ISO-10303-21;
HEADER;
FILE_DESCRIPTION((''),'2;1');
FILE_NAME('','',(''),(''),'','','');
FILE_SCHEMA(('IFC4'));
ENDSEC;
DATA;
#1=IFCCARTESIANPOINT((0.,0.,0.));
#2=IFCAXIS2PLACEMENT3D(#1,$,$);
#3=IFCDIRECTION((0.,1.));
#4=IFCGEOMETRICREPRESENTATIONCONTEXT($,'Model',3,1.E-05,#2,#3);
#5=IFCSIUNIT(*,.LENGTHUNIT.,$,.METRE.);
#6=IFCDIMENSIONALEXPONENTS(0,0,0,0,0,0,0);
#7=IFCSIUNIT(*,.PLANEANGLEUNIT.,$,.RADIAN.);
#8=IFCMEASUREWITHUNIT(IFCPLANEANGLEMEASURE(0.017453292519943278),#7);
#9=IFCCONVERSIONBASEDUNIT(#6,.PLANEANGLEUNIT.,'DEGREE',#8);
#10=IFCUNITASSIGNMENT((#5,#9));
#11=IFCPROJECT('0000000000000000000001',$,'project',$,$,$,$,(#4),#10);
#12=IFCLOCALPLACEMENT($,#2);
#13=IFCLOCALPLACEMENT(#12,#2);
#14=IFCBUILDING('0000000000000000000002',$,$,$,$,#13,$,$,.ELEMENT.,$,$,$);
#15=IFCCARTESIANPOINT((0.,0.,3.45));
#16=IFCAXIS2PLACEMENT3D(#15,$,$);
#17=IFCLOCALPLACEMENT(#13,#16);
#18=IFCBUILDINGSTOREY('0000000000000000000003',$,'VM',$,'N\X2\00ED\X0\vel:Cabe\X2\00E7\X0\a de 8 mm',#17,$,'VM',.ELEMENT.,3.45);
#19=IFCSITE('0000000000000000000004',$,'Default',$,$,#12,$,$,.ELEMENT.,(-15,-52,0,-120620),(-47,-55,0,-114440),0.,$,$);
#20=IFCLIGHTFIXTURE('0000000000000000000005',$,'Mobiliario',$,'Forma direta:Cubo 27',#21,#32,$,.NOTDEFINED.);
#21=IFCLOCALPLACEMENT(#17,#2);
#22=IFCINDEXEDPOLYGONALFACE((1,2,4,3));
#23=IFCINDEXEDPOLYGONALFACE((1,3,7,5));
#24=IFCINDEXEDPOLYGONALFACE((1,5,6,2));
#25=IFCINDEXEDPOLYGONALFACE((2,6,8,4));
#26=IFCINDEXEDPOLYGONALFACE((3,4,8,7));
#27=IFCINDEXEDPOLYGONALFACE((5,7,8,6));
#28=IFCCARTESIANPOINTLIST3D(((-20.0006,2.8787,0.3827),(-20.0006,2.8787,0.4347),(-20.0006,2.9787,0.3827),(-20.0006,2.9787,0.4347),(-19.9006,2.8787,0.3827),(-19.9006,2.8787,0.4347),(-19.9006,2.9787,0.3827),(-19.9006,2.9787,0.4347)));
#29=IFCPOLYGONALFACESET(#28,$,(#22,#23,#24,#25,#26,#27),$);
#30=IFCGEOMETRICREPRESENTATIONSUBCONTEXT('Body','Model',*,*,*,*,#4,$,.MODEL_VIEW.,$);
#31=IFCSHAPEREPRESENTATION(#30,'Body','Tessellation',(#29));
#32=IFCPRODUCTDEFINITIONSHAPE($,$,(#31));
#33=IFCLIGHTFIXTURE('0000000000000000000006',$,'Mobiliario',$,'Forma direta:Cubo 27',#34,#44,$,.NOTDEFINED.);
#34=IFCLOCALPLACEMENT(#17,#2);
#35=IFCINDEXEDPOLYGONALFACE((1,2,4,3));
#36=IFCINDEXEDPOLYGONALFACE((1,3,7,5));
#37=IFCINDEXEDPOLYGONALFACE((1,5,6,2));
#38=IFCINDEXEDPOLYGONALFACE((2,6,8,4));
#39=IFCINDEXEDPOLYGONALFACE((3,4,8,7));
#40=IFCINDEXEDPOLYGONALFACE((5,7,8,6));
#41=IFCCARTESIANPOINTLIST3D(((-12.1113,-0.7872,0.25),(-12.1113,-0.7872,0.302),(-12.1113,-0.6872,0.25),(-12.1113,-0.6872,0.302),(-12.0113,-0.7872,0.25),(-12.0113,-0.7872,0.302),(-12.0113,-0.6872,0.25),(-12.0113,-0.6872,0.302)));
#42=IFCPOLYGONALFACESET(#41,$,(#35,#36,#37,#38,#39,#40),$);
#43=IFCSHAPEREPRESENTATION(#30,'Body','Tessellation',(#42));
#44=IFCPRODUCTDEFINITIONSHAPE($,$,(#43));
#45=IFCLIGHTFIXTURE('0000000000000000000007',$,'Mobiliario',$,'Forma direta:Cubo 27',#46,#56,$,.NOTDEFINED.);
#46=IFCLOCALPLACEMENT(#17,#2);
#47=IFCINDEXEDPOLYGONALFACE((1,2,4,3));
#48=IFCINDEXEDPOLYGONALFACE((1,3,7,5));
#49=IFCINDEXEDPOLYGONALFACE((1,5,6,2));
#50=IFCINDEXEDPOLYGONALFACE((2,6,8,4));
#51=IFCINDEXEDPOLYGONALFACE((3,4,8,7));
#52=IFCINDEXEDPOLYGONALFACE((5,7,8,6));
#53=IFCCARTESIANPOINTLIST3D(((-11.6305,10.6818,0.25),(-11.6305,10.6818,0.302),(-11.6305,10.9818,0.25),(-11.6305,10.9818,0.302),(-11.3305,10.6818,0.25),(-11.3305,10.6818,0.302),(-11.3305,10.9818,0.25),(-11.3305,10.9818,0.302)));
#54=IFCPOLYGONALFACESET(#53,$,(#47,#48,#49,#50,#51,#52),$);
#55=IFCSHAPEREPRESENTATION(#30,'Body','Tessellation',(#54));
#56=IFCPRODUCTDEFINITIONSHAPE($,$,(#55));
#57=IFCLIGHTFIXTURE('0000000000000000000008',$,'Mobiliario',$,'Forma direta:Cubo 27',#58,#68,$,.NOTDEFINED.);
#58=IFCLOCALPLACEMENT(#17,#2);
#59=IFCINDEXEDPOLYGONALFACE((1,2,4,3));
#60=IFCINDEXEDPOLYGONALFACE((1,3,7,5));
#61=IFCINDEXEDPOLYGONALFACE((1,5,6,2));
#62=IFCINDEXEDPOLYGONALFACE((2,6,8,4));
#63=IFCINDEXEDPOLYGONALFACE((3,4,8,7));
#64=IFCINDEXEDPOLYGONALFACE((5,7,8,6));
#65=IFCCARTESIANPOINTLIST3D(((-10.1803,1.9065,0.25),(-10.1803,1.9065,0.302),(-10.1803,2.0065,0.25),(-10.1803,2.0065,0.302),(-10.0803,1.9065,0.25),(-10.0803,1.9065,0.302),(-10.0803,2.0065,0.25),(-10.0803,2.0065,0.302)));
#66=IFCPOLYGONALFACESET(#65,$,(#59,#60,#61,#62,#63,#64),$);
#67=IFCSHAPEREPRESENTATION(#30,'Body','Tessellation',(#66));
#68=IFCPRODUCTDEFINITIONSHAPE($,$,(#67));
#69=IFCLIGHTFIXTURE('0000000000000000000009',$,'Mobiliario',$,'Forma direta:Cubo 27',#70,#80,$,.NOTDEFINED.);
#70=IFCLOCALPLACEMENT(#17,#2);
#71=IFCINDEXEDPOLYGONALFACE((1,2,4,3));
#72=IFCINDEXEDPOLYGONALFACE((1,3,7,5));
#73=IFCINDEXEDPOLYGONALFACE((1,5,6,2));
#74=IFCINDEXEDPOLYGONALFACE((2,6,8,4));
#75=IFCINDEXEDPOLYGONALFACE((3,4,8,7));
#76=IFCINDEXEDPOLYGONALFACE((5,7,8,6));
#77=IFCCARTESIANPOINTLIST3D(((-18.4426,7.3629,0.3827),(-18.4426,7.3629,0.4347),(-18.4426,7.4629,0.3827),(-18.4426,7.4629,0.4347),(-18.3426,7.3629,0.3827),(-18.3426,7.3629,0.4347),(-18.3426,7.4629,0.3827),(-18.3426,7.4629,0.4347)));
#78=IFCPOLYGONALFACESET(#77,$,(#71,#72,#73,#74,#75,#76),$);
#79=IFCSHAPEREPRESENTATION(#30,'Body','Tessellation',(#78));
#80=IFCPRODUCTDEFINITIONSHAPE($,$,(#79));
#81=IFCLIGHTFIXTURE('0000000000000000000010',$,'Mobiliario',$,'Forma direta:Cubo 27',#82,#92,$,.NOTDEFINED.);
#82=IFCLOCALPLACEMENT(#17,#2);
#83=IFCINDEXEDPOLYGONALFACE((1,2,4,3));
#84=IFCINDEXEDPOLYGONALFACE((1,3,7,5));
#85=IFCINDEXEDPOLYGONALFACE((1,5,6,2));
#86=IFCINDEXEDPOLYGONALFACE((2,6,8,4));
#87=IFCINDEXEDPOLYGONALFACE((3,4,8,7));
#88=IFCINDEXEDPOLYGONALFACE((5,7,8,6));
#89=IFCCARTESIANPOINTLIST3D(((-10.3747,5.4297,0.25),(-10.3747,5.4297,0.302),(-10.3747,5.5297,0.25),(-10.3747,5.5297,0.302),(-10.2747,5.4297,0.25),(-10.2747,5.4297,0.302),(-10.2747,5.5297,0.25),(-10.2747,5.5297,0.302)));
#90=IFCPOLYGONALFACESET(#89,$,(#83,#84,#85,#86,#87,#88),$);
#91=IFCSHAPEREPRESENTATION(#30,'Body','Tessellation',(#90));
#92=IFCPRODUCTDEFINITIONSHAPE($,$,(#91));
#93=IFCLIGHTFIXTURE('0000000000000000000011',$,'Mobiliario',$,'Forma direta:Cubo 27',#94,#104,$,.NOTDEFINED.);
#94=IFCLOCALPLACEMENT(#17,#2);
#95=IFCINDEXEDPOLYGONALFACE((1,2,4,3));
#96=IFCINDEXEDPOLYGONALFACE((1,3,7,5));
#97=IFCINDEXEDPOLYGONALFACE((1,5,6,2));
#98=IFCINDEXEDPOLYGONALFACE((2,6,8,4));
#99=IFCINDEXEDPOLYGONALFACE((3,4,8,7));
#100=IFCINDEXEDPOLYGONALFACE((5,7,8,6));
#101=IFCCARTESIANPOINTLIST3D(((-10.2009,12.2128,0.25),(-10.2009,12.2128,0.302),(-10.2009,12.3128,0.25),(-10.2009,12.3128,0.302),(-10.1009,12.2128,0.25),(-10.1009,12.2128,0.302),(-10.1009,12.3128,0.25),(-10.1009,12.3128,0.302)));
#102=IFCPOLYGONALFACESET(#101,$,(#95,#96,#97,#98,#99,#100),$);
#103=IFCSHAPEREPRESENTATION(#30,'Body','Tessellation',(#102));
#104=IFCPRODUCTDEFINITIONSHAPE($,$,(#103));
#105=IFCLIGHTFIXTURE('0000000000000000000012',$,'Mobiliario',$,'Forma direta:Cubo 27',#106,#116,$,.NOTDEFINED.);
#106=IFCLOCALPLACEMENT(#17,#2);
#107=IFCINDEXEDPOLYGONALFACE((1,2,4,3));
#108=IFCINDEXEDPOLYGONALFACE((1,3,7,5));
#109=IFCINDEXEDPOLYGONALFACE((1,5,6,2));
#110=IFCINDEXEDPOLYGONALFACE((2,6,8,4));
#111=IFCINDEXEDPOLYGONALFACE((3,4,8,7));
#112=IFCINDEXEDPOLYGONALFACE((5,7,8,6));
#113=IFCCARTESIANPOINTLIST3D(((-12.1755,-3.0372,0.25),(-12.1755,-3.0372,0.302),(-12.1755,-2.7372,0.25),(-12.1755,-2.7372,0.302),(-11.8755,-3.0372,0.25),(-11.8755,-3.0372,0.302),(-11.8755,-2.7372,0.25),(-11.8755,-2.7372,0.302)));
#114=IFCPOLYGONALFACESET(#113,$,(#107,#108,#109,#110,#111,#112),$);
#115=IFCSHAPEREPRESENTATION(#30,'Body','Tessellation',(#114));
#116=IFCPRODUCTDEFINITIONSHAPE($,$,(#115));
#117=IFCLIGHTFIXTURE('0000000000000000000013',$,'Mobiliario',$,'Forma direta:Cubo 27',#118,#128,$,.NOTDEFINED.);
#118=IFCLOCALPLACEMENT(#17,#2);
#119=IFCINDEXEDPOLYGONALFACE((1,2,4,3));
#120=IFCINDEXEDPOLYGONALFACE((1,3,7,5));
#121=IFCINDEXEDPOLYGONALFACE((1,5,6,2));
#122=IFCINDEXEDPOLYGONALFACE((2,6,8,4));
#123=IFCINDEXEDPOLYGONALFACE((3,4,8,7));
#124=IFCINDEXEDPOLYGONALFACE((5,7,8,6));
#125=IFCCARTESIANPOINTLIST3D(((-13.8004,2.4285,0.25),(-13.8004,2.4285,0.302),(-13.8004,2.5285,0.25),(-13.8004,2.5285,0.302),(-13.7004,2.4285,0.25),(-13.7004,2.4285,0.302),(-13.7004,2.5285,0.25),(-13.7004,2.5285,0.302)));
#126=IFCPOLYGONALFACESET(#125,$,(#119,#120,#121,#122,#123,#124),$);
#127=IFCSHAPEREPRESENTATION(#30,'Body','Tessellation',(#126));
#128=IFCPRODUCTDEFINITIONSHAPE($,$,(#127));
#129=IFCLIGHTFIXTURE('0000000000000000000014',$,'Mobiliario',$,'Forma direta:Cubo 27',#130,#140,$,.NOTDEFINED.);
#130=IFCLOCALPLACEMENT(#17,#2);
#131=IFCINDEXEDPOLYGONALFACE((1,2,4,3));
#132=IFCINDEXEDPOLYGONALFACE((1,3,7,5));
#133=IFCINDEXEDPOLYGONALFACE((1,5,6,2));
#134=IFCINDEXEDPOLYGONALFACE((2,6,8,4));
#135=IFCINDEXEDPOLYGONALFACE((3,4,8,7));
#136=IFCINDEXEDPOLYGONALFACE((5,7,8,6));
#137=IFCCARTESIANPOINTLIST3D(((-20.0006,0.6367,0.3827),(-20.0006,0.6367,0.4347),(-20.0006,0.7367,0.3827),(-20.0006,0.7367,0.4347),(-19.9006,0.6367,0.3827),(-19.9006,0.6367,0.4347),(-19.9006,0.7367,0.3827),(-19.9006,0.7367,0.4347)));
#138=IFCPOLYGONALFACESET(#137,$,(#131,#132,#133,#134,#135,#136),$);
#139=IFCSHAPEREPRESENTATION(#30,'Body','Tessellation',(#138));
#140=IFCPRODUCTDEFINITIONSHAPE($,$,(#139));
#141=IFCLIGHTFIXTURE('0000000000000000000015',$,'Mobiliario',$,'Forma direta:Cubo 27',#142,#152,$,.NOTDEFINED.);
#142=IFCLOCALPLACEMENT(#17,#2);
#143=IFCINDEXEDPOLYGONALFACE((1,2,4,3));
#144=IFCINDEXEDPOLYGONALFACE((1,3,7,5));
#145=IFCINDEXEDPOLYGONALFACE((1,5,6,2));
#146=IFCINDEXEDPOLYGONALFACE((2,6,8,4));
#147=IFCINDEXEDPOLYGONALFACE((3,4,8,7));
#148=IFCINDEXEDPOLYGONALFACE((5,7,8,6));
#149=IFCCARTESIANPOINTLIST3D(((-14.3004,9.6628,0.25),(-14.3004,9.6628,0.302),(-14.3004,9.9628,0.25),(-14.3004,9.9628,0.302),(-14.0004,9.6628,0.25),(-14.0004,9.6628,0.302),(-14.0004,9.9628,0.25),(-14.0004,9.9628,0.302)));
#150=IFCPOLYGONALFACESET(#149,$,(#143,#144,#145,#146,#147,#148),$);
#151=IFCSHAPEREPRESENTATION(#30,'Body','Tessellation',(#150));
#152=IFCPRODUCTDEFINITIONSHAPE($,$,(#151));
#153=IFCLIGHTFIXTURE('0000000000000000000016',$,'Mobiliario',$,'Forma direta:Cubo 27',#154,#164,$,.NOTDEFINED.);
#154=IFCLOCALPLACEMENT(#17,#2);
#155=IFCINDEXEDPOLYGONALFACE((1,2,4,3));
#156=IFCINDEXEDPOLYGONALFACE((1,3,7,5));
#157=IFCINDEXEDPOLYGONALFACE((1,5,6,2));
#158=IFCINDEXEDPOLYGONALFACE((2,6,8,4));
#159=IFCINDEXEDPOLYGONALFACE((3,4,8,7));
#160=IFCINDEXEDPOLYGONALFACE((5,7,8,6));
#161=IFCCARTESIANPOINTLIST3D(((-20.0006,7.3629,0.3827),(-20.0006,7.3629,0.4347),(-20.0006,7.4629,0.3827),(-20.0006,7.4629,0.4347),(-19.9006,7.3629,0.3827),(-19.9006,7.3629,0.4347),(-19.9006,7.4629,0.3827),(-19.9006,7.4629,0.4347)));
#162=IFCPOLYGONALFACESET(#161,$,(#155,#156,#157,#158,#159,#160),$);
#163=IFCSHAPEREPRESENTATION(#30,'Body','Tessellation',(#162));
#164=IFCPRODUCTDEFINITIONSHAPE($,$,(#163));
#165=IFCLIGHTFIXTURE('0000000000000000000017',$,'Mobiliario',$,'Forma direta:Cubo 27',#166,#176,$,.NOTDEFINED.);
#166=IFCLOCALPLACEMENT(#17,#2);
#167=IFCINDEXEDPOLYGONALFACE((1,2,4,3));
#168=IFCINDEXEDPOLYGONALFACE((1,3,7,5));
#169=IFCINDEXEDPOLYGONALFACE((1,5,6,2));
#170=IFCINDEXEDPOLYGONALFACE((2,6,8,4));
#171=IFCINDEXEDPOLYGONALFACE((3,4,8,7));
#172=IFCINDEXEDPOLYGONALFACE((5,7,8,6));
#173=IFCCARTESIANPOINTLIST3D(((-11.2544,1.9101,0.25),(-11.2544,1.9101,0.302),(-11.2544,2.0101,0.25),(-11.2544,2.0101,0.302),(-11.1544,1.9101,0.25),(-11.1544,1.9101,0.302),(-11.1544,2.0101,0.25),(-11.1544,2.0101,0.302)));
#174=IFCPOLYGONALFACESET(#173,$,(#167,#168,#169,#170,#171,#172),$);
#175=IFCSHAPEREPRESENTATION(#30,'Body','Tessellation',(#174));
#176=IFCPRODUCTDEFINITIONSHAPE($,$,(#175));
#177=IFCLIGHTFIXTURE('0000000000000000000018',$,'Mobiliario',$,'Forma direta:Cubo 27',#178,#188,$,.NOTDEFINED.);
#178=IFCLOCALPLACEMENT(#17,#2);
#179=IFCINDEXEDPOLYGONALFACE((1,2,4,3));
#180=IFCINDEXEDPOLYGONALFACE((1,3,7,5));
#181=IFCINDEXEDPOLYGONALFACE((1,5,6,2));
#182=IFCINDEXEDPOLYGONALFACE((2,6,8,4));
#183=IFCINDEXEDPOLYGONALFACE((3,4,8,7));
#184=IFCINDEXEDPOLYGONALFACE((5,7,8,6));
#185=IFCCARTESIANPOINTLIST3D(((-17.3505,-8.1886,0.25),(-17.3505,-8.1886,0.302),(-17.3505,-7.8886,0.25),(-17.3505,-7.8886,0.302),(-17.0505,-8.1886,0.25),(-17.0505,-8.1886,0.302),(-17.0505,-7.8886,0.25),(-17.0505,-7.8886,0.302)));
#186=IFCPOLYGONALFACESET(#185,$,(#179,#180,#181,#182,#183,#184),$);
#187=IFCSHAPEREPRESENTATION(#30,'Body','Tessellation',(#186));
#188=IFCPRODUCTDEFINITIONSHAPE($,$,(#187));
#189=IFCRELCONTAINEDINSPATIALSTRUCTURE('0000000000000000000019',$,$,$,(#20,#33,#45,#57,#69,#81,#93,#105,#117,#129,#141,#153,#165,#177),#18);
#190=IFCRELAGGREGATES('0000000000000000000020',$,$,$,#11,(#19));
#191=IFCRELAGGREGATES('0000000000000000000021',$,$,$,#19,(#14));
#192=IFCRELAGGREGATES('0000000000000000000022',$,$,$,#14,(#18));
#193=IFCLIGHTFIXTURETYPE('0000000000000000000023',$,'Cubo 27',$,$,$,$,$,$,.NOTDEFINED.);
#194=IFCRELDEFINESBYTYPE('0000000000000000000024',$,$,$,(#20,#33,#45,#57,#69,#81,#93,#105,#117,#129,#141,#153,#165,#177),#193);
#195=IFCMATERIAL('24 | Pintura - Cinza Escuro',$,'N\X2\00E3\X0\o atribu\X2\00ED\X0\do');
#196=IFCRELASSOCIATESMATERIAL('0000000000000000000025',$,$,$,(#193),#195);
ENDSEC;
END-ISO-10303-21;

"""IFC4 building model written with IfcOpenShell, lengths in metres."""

from ifc_helpers import new_model, entity, si_unit, converted_unit, direction, frame, origin, place, context, subcontext, project, spatial, indexed_curve, outline, extrude, material, type_object, element, save


model = new_model("IFC4")

# Units and contexts
model_context = context("Model", 3, precision=1e-05, world=origin(), true_north=direction((0.0, 1.0)))
body_context = subcontext(model_context, "Body", "Model", "MODEL_VIEW")
ifc_project = project(units=[si_unit("LENGTHUNIT", "METRE"), converted_unit("PLANEANGLEUNIT", "DEGREE", entity("IfcPlaneAngleMeasure", 0.017453292519943278), si_unit("PLANEANGLEUNIT", "RADIAN"), dimensions=[0, 0, 0, 0, 0, 0, 0])], contexts=[model_context])

# Site, building, storey
site_placement = place(None, origin())
site = spatial("IfcSite", under=ifc_project, at=site_placement, Name="Default", CompositionType="ELEMENT", RefLatitude=(-15, -52, 0, -120620), RefLongitude=(-47, -55, 0, -114440), RefElevation=0.0)
building_placement = place(site_placement, origin())
building = spatial("IfcBuilding", under=site, at=building_placement, CompositionType="ELEMENT")
storey_placement = place(building_placement, frame((0.0, 0.0, 3.45)))
storey = spatial("IfcBuildingStorey", under=building, at=storey_placement, Name="VM", ObjectType="Nível:Cabeça de 8 mm", LongName="VM", CompositionType="ELEMENT", Elevation=3.45)

# Light fixtures
ifc_material_1 = material(Name="24 | Pintura - Cinza Escuro", Category="Não atribuído")
light_fixture_type = type_object("IfcLightFixtureType", Name="Cubo 27", PredefinedType="NOTDEFINED", material=ifc_material_1)
light_fixture_1_placement = place(storey_placement, origin())
element("IfcLightFixture", 1, at=light_fixture_1_placement, inside=storey, type_object=light_fixture_type, Name="Mobiliario", ObjectType="Forma direta:Cubo 27", PredefinedType="NOTDEFINED", context=body_context, shape_type="SweptSolid", body=[
    extrude(outline(indexed_curve([(-0.05, -0.05), (0.05, -0.05), (0.05, 0.05), (-0.05, 0.05), (-0.05, -0.05)], self_intersect=False)), frame((-19.9506, 2.9287, 0.3827), z_axis=(0.0, 0.0, 1.0), x_axis=(-0.000013, -1.0, 0.0)), (0.0, 0.0, 1.0), 0.052),
])
light_fixture_2_placement = place(storey_placement, origin())
element("IfcLightFixture", 2, at=light_fixture_2_placement, inside=storey, type_object=light_fixture_type, Name="Mobiliario", ObjectType="Forma direta:Cubo 27", PredefinedType="NOTDEFINED", context=body_context, shape_type="SweptSolid", body=[
    extrude(outline(indexed_curve([(-0.05, -0.05), (0.05, -0.05), (0.05, 0.05), (-0.05, 0.05), (-0.05, -0.05)], self_intersect=False)), frame((-12.0613, -0.7372, 0.25), z_axis=(0.0, 0.0, 1.0), x_axis=(-0.000013, -1.0, 0.0)), (0.0, 0.0, 1.0), 0.052),
])
light_fixture_3_placement = place(storey_placement, origin())
element("IfcLightFixture", 3, at=light_fixture_3_placement, inside=storey, type_object=light_fixture_type, Name="Mobiliario", ObjectType="Forma direta:Cubo 27", PredefinedType="NOTDEFINED", context=body_context, shape_type="SweptSolid", body=[
    extrude(outline(indexed_curve([(-0.15, -0.15), (0.15, -0.15), (0.15, 0.15), (-0.15, 0.15), (-0.15, -0.15)], self_intersect=False)), frame((-11.4805, 10.8318, 0.25)), (0.0, 0.0, 1.0), 0.052),
])
light_fixture_4_placement = place(storey_placement, origin())
element("IfcLightFixture", 4, at=light_fixture_4_placement, inside=storey, type_object=light_fixture_type, Name="Mobiliario", ObjectType="Forma direta:Cubo 27", PredefinedType="NOTDEFINED", context=body_context, shape_type="SweptSolid", body=[
    extrude(outline(indexed_curve([(-0.05, -0.05), (0.05, -0.05), (0.05, 0.05), (-0.05, 0.05), (-0.05, -0.05)], self_intersect=False)), frame((-10.1303, 1.9565, 0.25), z_axis=(0.0, 0.0, 1.0), x_axis=(-0.000013, -1.0, 0.0)), (0.0, 0.0, 1.0), 0.052),
])
light_fixture_5_placement = place(storey_placement, origin())
element("IfcLightFixture", 5, at=light_fixture_5_placement, inside=storey, type_object=light_fixture_type, Name="Mobiliario", ObjectType="Forma direta:Cubo 27", PredefinedType="NOTDEFINED", context=body_context, shape_type="SweptSolid", body=[
    extrude(outline(indexed_curve([(-0.05, -0.05), (0.05, -0.05), (0.05, 0.05), (-0.05, 0.05), (-0.05, -0.05)], self_intersect=False)), frame((-18.3926, 7.4129, 0.3827), z_axis=(0.0, 0.0, 1.0), x_axis=(-0.000013, -1.0, 0.0)), (0.0, 0.0, 1.0), 0.052),
])
light_fixture_6_placement = place(storey_placement, origin())
element("IfcLightFixture", 6, at=light_fixture_6_placement, inside=storey, type_object=light_fixture_type, Name="Mobiliario", ObjectType="Forma direta:Cubo 27", PredefinedType="NOTDEFINED", context=body_context, shape_type="SweptSolid", body=[
    extrude(outline(indexed_curve([(-0.05, -0.05), (0.05, -0.05), (0.05, 0.05), (-0.05, 0.05), (-0.05, -0.05)], self_intersect=False)), frame((-10.3247, 5.4797, 0.25), z_axis=(0.0, 0.0, 1.0), x_axis=(-0.000013, -1.0, 0.0)), (0.0, 0.0, 1.0), 0.052),
])
light_fixture_7_placement = place(storey_placement, origin())
element("IfcLightFixture", 7, at=light_fixture_7_placement, inside=storey, type_object=light_fixture_type, Name="Mobiliario", ObjectType="Forma direta:Cubo 27", PredefinedType="NOTDEFINED", context=body_context, shape_type="SweptSolid", body=[
    extrude(outline(indexed_curve([(-0.05, -0.05), (0.05, -0.05), (0.05, 0.05), (-0.05, 0.05), (-0.05, -0.05)], self_intersect=False)), frame((-10.1509, 12.2628, 0.25), z_axis=(0.0, 0.0, 1.0), x_axis=(-0.000013, -1.0, 0.0)), (0.0, 0.0, 1.0), 0.052),
])
light_fixture_8_placement = place(storey_placement, origin())
element("IfcLightFixture", 8, at=light_fixture_8_placement, inside=storey, type_object=light_fixture_type, Name="Mobiliario", ObjectType="Forma direta:Cubo 27", PredefinedType="NOTDEFINED", context=body_context, shape_type="SweptSolid", body=[
    extrude(outline(indexed_curve([(-0.15, -0.15), (0.15, -0.15), (0.15, 0.15), (-0.15, 0.15), (-0.15, -0.15)], self_intersect=False)), frame((-12.0255, -2.8872, 0.25)), (0.0, 0.0, 1.0), 0.052),
])
light_fixture_9_placement = place(storey_placement, origin())
element("IfcLightFixture", 9, at=light_fixture_9_placement, inside=storey, type_object=light_fixture_type, Name="Mobiliario", ObjectType="Forma direta:Cubo 27", PredefinedType="NOTDEFINED", context=body_context, shape_type="SweptSolid", body=[
    extrude(outline(indexed_curve([(-0.05, -0.05), (0.05, -0.05), (0.05, 0.05), (-0.05, 0.05), (-0.05, -0.05)], self_intersect=False)), frame((-13.7504, 2.4785, 0.25), z_axis=(0.0, 0.0, 1.0), x_axis=(-0.000013, -1.0, 0.0)), (0.0, 0.0, 1.0), 0.052),
])
light_fixture_10_placement = place(storey_placement, origin())
element("IfcLightFixture", 10, at=light_fixture_10_placement, inside=storey, type_object=light_fixture_type, Name="Mobiliario", ObjectType="Forma direta:Cubo 27", PredefinedType="NOTDEFINED", context=body_context, shape_type="SweptSolid", body=[
    extrude(outline(indexed_curve([(-0.05, -0.05), (0.05, -0.05), (0.05, 0.05), (-0.05, 0.05), (-0.05, -0.05)], self_intersect=False)), frame((-19.9506, 0.6867, 0.3827), z_axis=(0.0, 0.0, 1.0), x_axis=(-0.000013, -1.0, 0.0)), (0.0, 0.0, 1.0), 0.052),
])
light_fixture_11_placement = place(storey_placement, origin())
element("IfcLightFixture", 11, at=light_fixture_11_placement, inside=storey, type_object=light_fixture_type, Name="Mobiliario", ObjectType="Forma direta:Cubo 27", PredefinedType="NOTDEFINED", context=body_context, shape_type="SweptSolid", body=[
    extrude(outline(indexed_curve([(-0.15, -0.15), (0.15, -0.15), (0.15, 0.15), (-0.15, 0.15), (-0.15, -0.15)], self_intersect=False)), frame((-14.1504, 9.8128, 0.25)), (0.0, 0.0, 1.0), 0.052),
])
light_fixture_12_placement = place(storey_placement, origin())
element("IfcLightFixture", 12, at=light_fixture_12_placement, inside=storey, type_object=light_fixture_type, Name="Mobiliario", ObjectType="Forma direta:Cubo 27", PredefinedType="NOTDEFINED", context=body_context, shape_type="SweptSolid", body=[
    extrude(outline(indexed_curve([(-0.05, -0.05), (0.05, -0.05), (0.05, 0.05), (-0.05, 0.05), (-0.05, -0.05)], self_intersect=False)), frame((-19.9506, 7.4129, 0.3827), z_axis=(0.0, 0.0, 1.0), x_axis=(-0.000013, -1.0, 0.0)), (0.0, 0.0, 1.0), 0.052),
])
light_fixture_13_placement = place(storey_placement, origin())
element("IfcLightFixture", 13, at=light_fixture_13_placement, inside=storey, type_object=light_fixture_type, Name="Mobiliario", ObjectType="Forma direta:Cubo 27", PredefinedType="NOTDEFINED", context=body_context, shape_type="SweptSolid", body=[
    extrude(outline(indexed_curve([(-0.05, -0.05), (0.05, -0.05), (0.05, 0.05), (-0.05, 0.05), (-0.05, -0.05)], self_intersect=False)), frame((-11.2044, 1.9601, 0.25), z_axis=(0.0, 0.0, 1.0), x_axis=(-0.000013, -1.0, 0.0)), (0.0, 0.0, 1.0), 0.052),
])
light_fixture_14_placement = place(storey_placement, origin())
element("IfcLightFixture", 14, at=light_fixture_14_placement, inside=storey, type_object=light_fixture_type, Name="Mobiliario", ObjectType="Forma direta:Cubo 27", PredefinedType="NOTDEFINED", context=body_context, shape_type="SweptSolid", body=[
    extrude(outline(indexed_curve([(-0.15, -0.15), (0.15, -0.15), (0.15, 0.15), (-0.15, 0.15), (-0.15, -0.15)], self_intersect=False)), frame((-17.2005, -8.0386, 0.25)), (0.0, 0.0, 1.0), 0.052),
])

save(model, "model.ifc")
